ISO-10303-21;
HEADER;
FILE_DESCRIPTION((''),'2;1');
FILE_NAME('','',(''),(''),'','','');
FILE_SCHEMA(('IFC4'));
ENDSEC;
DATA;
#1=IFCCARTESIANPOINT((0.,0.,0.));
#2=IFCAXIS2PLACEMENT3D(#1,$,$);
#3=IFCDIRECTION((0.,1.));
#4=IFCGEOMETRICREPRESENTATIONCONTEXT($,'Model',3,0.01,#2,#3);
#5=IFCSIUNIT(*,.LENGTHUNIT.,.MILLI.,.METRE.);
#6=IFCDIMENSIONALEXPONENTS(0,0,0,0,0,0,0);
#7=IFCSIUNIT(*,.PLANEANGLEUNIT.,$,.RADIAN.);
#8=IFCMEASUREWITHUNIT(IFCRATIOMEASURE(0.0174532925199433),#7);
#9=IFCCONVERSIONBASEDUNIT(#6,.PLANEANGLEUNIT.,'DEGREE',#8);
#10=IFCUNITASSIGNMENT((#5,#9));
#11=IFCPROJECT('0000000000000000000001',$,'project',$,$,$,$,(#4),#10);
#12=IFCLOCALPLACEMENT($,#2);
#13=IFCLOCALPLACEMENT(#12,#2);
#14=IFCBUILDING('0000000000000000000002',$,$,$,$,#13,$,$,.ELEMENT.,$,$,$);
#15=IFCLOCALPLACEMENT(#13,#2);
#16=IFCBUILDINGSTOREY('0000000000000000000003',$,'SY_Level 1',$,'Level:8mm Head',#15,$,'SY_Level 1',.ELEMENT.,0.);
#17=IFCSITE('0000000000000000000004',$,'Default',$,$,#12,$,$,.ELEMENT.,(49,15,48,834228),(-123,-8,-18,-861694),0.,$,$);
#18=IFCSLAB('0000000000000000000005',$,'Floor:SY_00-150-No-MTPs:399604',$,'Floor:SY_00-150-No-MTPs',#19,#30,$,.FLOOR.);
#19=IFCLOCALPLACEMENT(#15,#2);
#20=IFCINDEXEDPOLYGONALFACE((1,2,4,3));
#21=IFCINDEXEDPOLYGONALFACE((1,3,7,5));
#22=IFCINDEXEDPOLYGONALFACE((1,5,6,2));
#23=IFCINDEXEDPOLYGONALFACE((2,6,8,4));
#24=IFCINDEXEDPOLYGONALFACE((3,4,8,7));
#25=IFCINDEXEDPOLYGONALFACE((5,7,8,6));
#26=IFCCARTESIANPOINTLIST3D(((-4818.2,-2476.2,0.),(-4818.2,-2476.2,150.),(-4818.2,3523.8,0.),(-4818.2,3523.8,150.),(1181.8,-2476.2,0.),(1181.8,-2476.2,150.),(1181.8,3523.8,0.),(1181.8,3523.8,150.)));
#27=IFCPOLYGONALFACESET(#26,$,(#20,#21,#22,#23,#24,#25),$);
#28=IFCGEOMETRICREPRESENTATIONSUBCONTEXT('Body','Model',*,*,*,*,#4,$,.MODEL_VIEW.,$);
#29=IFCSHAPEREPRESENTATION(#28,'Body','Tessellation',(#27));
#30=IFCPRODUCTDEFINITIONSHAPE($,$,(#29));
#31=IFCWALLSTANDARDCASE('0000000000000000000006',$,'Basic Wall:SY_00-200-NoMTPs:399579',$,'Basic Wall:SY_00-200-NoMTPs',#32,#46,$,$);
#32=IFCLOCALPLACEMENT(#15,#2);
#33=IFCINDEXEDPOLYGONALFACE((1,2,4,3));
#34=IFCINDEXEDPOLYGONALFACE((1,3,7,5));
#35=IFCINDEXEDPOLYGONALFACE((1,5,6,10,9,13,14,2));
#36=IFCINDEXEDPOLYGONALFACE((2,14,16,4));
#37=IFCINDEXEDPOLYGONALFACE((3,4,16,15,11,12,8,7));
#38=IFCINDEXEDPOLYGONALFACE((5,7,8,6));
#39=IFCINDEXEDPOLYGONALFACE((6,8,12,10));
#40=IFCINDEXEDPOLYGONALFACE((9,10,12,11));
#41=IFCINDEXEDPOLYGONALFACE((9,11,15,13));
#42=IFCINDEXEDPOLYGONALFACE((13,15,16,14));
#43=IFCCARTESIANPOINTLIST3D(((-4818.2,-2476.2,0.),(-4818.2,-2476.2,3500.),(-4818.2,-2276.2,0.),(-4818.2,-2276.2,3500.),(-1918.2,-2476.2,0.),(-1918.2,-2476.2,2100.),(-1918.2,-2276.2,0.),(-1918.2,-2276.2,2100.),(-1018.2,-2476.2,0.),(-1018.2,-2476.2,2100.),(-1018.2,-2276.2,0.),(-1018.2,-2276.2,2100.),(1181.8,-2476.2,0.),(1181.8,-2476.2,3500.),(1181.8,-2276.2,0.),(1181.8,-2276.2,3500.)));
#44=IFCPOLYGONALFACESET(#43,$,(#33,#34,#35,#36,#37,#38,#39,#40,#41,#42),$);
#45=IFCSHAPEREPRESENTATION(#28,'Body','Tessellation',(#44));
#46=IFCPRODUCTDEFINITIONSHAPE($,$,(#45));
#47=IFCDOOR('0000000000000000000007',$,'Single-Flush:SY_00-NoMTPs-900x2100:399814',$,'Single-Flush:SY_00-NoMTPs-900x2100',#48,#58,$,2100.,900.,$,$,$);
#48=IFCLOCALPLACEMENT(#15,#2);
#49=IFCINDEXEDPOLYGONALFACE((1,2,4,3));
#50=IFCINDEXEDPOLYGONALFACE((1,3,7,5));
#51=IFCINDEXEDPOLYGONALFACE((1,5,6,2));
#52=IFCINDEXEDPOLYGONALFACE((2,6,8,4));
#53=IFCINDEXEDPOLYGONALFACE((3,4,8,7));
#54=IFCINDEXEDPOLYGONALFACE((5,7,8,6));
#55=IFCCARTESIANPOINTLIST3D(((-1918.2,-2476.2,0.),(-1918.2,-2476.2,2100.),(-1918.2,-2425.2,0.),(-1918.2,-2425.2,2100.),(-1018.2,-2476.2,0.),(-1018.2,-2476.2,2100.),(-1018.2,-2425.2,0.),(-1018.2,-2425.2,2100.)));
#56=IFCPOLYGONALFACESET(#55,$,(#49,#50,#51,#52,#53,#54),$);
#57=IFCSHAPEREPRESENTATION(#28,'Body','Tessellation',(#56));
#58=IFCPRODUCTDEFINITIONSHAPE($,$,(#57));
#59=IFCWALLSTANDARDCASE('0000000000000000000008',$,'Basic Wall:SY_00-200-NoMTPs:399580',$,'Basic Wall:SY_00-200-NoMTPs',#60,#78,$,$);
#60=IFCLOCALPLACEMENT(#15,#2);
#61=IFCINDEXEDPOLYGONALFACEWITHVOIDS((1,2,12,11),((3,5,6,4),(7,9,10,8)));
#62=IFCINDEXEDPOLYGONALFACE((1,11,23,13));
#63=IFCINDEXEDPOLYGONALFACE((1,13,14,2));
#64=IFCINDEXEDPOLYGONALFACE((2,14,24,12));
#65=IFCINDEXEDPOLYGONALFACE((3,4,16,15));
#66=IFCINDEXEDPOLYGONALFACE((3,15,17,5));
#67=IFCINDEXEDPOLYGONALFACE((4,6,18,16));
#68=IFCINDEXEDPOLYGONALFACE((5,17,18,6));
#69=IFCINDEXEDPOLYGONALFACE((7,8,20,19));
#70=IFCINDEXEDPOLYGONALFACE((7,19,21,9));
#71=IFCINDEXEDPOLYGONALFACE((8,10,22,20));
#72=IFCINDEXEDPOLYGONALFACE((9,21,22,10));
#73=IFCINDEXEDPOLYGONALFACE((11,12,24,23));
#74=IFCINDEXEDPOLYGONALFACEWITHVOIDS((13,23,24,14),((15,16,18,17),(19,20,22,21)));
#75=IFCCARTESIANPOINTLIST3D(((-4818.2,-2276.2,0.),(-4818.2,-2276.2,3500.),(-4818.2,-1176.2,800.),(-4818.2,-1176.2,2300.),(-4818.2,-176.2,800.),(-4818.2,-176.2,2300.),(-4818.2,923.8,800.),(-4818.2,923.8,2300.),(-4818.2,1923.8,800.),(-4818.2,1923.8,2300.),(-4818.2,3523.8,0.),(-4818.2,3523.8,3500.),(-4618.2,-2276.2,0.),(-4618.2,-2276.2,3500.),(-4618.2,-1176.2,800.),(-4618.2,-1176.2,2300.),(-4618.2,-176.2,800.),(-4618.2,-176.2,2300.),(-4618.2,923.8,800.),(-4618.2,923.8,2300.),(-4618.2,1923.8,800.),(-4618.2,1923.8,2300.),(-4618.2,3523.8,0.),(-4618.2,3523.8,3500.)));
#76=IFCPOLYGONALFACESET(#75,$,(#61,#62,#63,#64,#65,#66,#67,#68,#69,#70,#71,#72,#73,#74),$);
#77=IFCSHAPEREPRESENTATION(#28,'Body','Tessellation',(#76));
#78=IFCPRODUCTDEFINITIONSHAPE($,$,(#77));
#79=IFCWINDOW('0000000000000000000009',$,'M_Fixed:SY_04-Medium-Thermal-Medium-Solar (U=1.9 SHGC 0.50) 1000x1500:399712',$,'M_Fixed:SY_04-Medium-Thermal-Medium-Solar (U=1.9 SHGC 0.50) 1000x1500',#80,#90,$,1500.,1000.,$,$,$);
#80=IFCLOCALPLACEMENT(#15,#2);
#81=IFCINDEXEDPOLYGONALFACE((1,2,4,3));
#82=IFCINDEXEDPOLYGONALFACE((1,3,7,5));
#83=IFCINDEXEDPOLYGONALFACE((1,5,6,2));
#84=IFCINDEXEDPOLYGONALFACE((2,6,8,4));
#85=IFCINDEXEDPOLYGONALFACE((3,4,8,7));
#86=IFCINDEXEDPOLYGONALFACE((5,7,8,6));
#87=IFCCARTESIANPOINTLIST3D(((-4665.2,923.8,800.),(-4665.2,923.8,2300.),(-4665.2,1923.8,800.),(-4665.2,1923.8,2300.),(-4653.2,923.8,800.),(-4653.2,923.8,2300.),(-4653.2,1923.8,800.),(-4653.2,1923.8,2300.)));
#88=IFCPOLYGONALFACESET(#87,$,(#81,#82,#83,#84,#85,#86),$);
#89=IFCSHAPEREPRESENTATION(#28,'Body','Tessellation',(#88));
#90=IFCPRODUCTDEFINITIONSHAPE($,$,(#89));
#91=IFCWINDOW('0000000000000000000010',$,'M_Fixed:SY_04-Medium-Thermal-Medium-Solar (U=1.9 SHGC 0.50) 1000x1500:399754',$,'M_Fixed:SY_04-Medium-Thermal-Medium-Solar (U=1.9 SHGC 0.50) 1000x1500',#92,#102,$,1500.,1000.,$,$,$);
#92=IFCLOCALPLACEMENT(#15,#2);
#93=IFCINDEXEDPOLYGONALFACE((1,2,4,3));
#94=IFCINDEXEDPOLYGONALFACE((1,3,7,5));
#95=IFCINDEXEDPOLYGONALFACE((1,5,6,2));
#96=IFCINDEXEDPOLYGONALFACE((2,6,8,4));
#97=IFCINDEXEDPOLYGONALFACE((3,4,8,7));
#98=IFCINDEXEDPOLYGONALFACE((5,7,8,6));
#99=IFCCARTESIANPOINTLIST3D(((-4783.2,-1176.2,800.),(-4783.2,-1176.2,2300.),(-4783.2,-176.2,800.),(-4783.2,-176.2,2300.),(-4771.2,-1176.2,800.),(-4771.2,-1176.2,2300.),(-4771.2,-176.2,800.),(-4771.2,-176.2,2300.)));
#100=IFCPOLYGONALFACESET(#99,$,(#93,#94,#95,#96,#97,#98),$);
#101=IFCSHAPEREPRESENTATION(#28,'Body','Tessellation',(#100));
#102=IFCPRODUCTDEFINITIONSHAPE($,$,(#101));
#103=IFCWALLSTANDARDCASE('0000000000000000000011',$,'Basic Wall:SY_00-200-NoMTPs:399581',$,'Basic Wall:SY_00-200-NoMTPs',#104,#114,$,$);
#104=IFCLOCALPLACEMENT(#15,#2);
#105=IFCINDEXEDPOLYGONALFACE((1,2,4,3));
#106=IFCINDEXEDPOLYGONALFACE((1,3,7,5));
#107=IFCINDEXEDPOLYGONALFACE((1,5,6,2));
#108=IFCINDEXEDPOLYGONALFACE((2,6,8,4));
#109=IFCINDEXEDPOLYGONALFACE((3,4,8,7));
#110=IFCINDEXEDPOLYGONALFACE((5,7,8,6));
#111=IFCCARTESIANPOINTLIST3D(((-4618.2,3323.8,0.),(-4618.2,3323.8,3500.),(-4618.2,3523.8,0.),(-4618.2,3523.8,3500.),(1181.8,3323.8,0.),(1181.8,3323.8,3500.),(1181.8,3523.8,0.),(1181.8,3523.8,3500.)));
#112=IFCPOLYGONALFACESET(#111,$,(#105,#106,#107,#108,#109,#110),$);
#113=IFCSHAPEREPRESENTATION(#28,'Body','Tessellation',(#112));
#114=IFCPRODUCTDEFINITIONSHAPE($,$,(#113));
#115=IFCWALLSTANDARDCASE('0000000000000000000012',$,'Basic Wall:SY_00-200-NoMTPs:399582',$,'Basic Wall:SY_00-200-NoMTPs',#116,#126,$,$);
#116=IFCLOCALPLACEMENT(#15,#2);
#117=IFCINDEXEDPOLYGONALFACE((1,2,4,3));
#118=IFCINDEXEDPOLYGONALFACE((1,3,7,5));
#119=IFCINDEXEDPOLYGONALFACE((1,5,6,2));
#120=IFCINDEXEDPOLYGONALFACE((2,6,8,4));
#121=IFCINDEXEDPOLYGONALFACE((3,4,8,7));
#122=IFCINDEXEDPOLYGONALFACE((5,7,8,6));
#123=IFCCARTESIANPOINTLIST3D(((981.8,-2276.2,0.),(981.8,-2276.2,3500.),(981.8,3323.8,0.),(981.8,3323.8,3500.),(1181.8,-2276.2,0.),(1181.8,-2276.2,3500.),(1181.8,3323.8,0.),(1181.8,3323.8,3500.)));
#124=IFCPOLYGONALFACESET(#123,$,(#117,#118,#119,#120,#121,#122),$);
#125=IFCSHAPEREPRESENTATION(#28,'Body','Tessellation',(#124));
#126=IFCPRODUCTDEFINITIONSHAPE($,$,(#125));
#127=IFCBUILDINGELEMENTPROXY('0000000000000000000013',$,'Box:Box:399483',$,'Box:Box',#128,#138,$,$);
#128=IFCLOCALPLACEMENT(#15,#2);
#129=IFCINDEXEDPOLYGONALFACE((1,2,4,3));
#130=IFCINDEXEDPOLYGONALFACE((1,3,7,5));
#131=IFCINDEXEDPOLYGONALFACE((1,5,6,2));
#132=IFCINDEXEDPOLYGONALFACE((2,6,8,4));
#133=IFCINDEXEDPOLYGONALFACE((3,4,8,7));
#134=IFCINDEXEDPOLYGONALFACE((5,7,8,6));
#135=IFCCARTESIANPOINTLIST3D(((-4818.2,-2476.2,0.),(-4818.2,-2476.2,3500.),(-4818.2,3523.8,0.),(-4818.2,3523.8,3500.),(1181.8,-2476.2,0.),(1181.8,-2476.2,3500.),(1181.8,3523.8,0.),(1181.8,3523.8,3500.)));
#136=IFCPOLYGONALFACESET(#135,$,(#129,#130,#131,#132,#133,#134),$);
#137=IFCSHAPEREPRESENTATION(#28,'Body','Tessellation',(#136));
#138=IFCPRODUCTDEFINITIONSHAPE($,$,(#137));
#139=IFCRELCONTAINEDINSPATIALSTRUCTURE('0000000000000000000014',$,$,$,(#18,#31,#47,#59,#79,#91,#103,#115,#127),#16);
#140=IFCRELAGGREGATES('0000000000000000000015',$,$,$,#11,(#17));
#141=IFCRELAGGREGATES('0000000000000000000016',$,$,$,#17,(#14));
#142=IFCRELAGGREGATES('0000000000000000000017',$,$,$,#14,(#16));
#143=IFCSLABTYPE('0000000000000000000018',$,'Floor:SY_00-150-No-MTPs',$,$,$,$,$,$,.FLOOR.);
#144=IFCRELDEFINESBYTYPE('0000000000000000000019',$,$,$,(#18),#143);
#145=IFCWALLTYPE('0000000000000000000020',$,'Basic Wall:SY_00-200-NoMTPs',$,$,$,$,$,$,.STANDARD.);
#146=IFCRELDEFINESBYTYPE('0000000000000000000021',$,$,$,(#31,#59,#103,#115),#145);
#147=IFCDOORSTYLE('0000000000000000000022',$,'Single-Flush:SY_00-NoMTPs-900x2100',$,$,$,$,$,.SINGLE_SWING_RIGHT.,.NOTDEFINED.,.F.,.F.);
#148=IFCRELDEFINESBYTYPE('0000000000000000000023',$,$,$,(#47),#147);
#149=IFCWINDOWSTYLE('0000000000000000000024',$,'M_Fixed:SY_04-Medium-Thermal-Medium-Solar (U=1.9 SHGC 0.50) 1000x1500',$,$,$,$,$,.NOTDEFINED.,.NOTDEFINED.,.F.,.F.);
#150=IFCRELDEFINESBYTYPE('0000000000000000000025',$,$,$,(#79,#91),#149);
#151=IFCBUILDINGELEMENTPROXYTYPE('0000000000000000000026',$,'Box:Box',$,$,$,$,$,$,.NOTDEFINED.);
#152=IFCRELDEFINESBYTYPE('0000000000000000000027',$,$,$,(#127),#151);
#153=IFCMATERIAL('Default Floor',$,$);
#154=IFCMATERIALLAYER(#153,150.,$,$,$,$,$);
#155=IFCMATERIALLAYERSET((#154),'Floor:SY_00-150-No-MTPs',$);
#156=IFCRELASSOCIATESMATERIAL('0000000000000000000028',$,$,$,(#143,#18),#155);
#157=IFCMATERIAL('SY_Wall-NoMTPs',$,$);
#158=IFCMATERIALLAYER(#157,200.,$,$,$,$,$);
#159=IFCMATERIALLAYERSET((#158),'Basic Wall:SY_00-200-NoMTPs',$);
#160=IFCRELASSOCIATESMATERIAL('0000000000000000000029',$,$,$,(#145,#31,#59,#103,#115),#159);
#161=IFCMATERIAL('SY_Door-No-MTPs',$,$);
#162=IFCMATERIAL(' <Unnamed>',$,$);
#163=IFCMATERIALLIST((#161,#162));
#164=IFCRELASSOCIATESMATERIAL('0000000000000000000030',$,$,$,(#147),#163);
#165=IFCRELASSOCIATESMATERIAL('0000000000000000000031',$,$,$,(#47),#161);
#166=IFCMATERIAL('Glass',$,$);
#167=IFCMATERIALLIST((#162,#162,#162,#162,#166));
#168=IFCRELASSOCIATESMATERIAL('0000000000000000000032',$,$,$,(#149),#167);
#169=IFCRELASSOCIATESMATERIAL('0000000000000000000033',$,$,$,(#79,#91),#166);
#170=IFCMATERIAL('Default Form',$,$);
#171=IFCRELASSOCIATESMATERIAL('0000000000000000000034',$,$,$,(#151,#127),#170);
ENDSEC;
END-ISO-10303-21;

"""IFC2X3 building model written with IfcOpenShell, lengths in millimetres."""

from ifc_helpers import new_model, entity, si_unit, converted_unit, direction, frame, frame_2d, origin, origin_2d_with_axis, place, context, subcontext, project, spatial, rectangle, extrude, source, transform, mapped, material, material_list, layer, layer_set, layer_usage, type_object, type_shapes, element, fill, save


model = new_model("IFC2X3")

# Units and contexts
model_context = context("Model", 3, precision=0.01, world=origin(), true_north=direction((0.0, 1.0)))
body_context = subcontext(model_context, "Body", "Model", "MODEL_VIEW")
ifc_project = project(units=[si_unit("LENGTHUNIT", "METRE", prefix="MILLI"), converted_unit("PLANEANGLEUNIT", "DEGREE", entity("IfcRatioMeasure", 0.0174532925199433), si_unit("PLANEANGLEUNIT", "RADIAN"), dimensions=[0, 0, 0, 0, 0, 0, 0])], contexts=[model_context])

# Site, building, storey
site_placement = place(None, origin())
site = spatial("IfcSite", under=ifc_project, at=site_placement, Name="Default", CompositionType="ELEMENT", RefLatitude=(49, 15, 48, 834228), RefLongitude=(-123, -8, -18, -861694), RefElevation=0.0)
building_placement = place(site_placement, origin())
building = spatial("IfcBuilding", under=site, at=building_placement, CompositionType="ELEMENT")
storey_placement = place(building_placement, origin())
storey = spatial("IfcBuildingStorey", under=building, at=storey_placement, Name="SY_Level 1", ObjectType="Level:8mm Head", LongName="SY_Level 1", CompositionType="ELEMENT", Elevation=0.0)

# Slab
ifc_material_1 = material(Name="Default Floor")
ifc_layer_1 = layer(ifc_material_1, 150.0)
ifc_layer_set_1 = layer_set([ifc_layer_1], Name="Floor:SY_00-150-No-MTPs")
ifc_layer_usage_1 = layer_usage(ifc_layer_set_1, "AXIS3", "POSITIVE", 0.0)
slab_type = type_object("IfcSlabType", Name="Floor:SY_00-150-No-MTPs", PredefinedType="FLOOR", material=ifc_layer_set_1)
slab_placement = place(storey_placement, origin())
element("IfcSlab", 1, at=slab_placement, inside=storey, type_object=slab_type, material=ifc_layer_usage_1, Name="Floor:SY_00-150-No-MTPs:399604", ObjectType="Floor:SY_00-150-No-MTPs", PredefinedType="FLOOR", context=body_context, shape_type="SweptSolid", body=[
    extrude(rectangle(XDim=6000.0, YDim=6000.0, at=origin_2d_with_axis()), frame((-1818.2, 523.8, 150.0), z_axis=(0.0, 0.0, -1.0), x_axis=(0.0, 1.0, 0.0)), (0.0, 0.0, 1.0), 150.0),
])

# Wall, opening, door
ifc_material_2 = material(Name="SY_Wall-NoMTPs")
ifc_layer_2 = layer(ifc_material_2, 200.0)
ifc_layer_set_2 = layer_set([ifc_layer_2], Name="Basic Wall:SY_00-200-NoMTPs")
ifc_layer_usage_2 = layer_usage(ifc_layer_set_2, "AXIS2", "POSITIVE", -100.0)
wall_type = type_object("IfcWallType", Name="Basic Wall:SY_00-200-NoMTPs", PredefinedType="STANDARD", material=ifc_layer_set_2)
wall_1_placement = place(storey_placement, frame((-4818.2, -2376.2, 0.0)))
wall_1 = element("IfcWallStandardCase", 2, at=wall_1_placement, inside=storey, type_object=wall_type, material=ifc_layer_usage_2, Name="Basic Wall:SY_00-200-NoMTPs:399579", ObjectType="Basic Wall:SY_00-200-NoMTPs", context=body_context, shape_type="SweptSolid", body=[
    extrude(rectangle(XDim=6000.0, YDim=200.0, at=frame_2d((3000.0, 0.0), x_axis=(-1.0, 0.0))), origin(), (0.0, 0.0, 1.0), 3500.0),
])
opening_1_placement = place(wall_1_placement, frame((3800.0, 100.0, 0.0)))
opening_1 = element("IfcOpeningElement", 3, at=opening_1_placement, cuts=wall_1, ObjectType="Opening", context=body_context, shape_type="SweptSolid", body=[
    extrude(rectangle(XDim=900.0, YDim=2100.0, at=frame_2d((1050.0, 450.0), x_axis=(0.0, 1.0))), frame((0.0, 0.0, 0.0), z_axis=(0.0, -1.0, 0.0), x_axis=(0.0, 0.0, 1.0)), (0.0, 0.0, 1.0), 200.0),
])
ifc_material_3 = material(Name="SY_Door-No-MTPs")
ifc_material_4 = material(Name=" <Unnamed>")
ifc_material_list_1 = material_list([ifc_material_3, ifc_material_4])
door_style = type_object("IfcDoorStyle", Name="Single-Flush:SY_00-NoMTPs-900x2100", ConstructionType="NOTDEFINED", OperationType="SINGLE_SWING_RIGHT", ParameterTakesPrecedence=False, Sizeable=False, material=ifc_material_list_1)
shared_shape_1 = source(origin(), body_context, "Body", "SweptSolid", [
    extrude(rectangle(XDim=51.0, YDim=900.0, at=frame_2d((0.0, 0.0), x_axis=(1.0, 0.0))), frame((450.0, 174.5, 0.0), z_axis=(0.0, 0.0, 1.0), x_axis=(0.0, 1.0, 0.0)), (0.0, 0.0, 1.0), 2100.0),
])
type_shapes(door_style, [shared_shape_1])
door_placement = place(opening_1_placement, frame((0.0, 0.0, 0.0), z_axis=(0.0, 0.0, 1.0), x_axis=(-1.0, 0.0, 0.0)))
door = element("IfcDoor", 4, at=door_placement, inside=storey, type_object=door_style, material=ifc_material_3, Name="Single-Flush:SY_00-NoMTPs-900x2100:399814", ObjectType="Single-Flush:SY_00-NoMTPs-900x2100", OverallHeight=2100.0, OverallWidth=900.0, context=body_context, shape_type="MappedRepresentation", body=[
    mapped(shared_shape_1, transform((0.0, 0.0, 0.0), scale=1.0)),
])
fill(opening_1, door)

# Wall, openings, windows
ifc_layer_usage_3 = layer_usage(ifc_layer_set_2, "AXIS2", "POSITIVE", -100.0)
wall_2_placement = place(storey_placement, frame((-4718.2, 3523.8, 0.0), z_axis=(0.0, 0.0, 1.0), x_axis=(0.0, -1.0, 0.0)))
wall_2 = element("IfcWallStandardCase", 5, at=wall_2_placement, inside=storey, type_object=wall_type, material=ifc_layer_usage_3, Name="Basic Wall:SY_00-200-NoMTPs:399580", ObjectType="Basic Wall:SY_00-200-NoMTPs", context=body_context, shape_type="SweptSolid", body=[
    extrude(rectangle(XDim=5800.0, YDim=200.0, at=frame_2d((2900.0, 0.0), x_axis=(-1.0, 0.0))), origin(), (0.0, 0.0, 1.0), 3500.0),
])
opening_2_placement = place(wall_2_placement, frame((1600.0, -100.0, 800.0)))
opening_2 = element("IfcOpeningElement", 6, at=opening_2_placement, cuts=wall_2, ObjectType="Opening", context=body_context, shape_type="SweptSolid", body=[
    extrude(rectangle(XDim=1500.0, YDim=1000.0, at=frame_2d((750.0, 500.0), x_axis=(1.0, 0.0))), frame((0.0, 0.0, 0.0), z_axis=(0.0, 1.0, 0.0), x_axis=(0.0, 0.0, 1.0)), (0.0, 0.0, 1.0), 200.0),
])
opening_3_placement = place(wall_2_placement, frame((4700.0, 100.0, 800.0)))
opening_3 = element("IfcOpeningElement", 7, at=opening_3_placement, cuts=wall_2, ObjectType="Opening", context=body_context, shape_type="SweptSolid", body=[
    extrude(rectangle(XDim=1500.0, YDim=1000.0, at=frame_2d((750.0, 500.0), x_axis=(1.0, 0.0))), frame((0.0, 0.0, 0.0), z_axis=(0.0, -1.0, 0.0), x_axis=(0.0, 0.0, 1.0)), (0.0, 0.0, 1.0), 200.0),
])
ifc_material_5 = material(Name="Glass")
ifc_material_list_2 = material_list([ifc_material_4, ifc_material_4, ifc_material_4, ifc_material_4, ifc_material_5])
window_style = type_object("IfcWindowStyle", Name="M_Fixed:SY_04-Medium-Thermal-Medium-Solar (U=1.9 SHGC 0.50) 1000x1500", ConstructionType="NOTDEFINED", OperationType="NOTDEFINED", ParameterTakesPrecedence=False, Sizeable=False, material=ifc_material_list_2)
shared_shape_2 = source(origin(), body_context, "Body", "SweptSolid", [
    extrude(rectangle(XDim=12.0, YDim=1000.0, at=frame_2d((0.0, 0.0), x_axis=(1.0, 0.0))), frame((500.0, 159.0, 0.0), z_axis=(0.0, 0.0, 1.0), x_axis=(0.0, -1.0, 0.0)), (0.0, 0.0, 1.0), 1500.0),
])
type_shapes(window_style, [shared_shape_2])
window_1_placement = place(opening_2_placement, origin())
window_1 = element("IfcWindow", 8, at=window_1_placement, inside=storey, type_object=window_style, material=ifc_material_5, Name="M_Fixed:SY_04-Medium-Thermal-Medium-Solar (U=1.9 SHGC 0.50) 1000x1500:399712", ObjectType="M_Fixed:SY_04-Medium-Thermal-Medium-Solar (U=1.9 SHGC 0.50) 1000x1500", OverallHeight=1500.0, OverallWidth=1000.0, context=body_context, shape_type="MappedRepresentation", body=[
    mapped(shared_shape_2, transform((0.0, 0.0, 0.0), scale=1.0)),
])
fill(opening_2, window_1)
window_2_placement = place(opening_3_placement, frame((0.0, 0.0, 0.0), z_axis=(0.0, 0.0, 1.0), x_axis=(-1.0, 0.0, 0.0)))
window_2 = element("IfcWindow", 9, at=window_2_placement, inside=storey, type_object=window_style, material=ifc_material_5, Name="M_Fixed:SY_04-Medium-Thermal-Medium-Solar (U=1.9 SHGC 0.50) 1000x1500:399754", ObjectType="M_Fixed:SY_04-Medium-Thermal-Medium-Solar (U=1.9 SHGC 0.50) 1000x1500", OverallHeight=1500.0, OverallWidth=1000.0, context=body_context, shape_type="MappedRepresentation", body=[
    mapped(shared_shape_2, transform((0.0, 0.0, 0.0), scale=1.0)),
])
fill(opening_3, window_2)

# Walls
ifc_layer_usage_4 = layer_usage(ifc_layer_set_2, "AXIS2", "POSITIVE", -100.0)
wall_3_placement = place(storey_placement, frame((1181.8, 3423.8, 0.0), z_axis=(0.0, 0.0, 1.0), x_axis=(-1.0, 0.0, 0.0)))
element("IfcWallStandardCase", 10, at=wall_3_placement, inside=storey, type_object=wall_type, material=ifc_layer_usage_4, Name="Basic Wall:SY_00-200-NoMTPs:399581", ObjectType="Basic Wall:SY_00-200-NoMTPs", context=body_context, shape_type="SweptSolid", body=[
    extrude(rectangle(XDim=5800.0, YDim=200.0, at=frame_2d((2900.0, 0.0), x_axis=(-1.0, 0.0))), origin(), (0.0, 0.0, 1.0), 3500.0),
])
ifc_layer_usage_5 = layer_usage(ifc_layer_set_2, "AXIS2", "POSITIVE", -100.0)
wall_4_placement = place(storey_placement, frame((1081.8, -2276.2, 0.0), z_axis=(0.0, 0.0, 1.0), x_axis=(0.0, 1.0, 0.0)))
element("IfcWallStandardCase", 11, at=wall_4_placement, inside=storey, type_object=wall_type, material=ifc_layer_usage_5, Name="Basic Wall:SY_00-200-NoMTPs:399582", ObjectType="Basic Wall:SY_00-200-NoMTPs", context=body_context, shape_type="SweptSolid", body=[
    extrude(rectangle(XDim=5600.0, YDim=200.0, at=frame_2d((2800.0, 0.0), x_axis=(-1.0, 0.0))), origin(), (0.0, 0.0, 1.0), 3500.0),
])

# Building element proxy
ifc_material_6 = material(Name="Default Form")
building_element_proxy_type = type_object("IfcBuildingElementProxyType", Name="Box:Box", PredefinedType="NOTDEFINED", material=ifc_material_6)
shared_shape_3 = source(origin(), body_context, "Body", "SweptSolid", [
    extrude(rectangle(XDim=6000.0, YDim=6000.0, at=origin_2d_with_axis()), frame((-1818.2, 523.8, 0.0), z_axis=(0.0, 0.0, 1.0), x_axis=(-1.0, 0.0, 0.0)), (0.0, 0.0, 1.0), 3500.0),
])
type_shapes(building_element_proxy_type, [shared_shape_3])
proxy_placement = place(storey_placement, origin())
element("IfcBuildingElementProxy", 12, at=proxy_placement, inside=storey, type_object=building_element_proxy_type, material=ifc_material_6, Name="Box:Box:399483", ObjectType="Box:Box", context=body_context, shape_type="MappedRepresentation", body=[
    mapped(shared_shape_3, transform((0.0, 0.0, 0.0), scale=1.0)),
])

save(model, "model.ifc")
